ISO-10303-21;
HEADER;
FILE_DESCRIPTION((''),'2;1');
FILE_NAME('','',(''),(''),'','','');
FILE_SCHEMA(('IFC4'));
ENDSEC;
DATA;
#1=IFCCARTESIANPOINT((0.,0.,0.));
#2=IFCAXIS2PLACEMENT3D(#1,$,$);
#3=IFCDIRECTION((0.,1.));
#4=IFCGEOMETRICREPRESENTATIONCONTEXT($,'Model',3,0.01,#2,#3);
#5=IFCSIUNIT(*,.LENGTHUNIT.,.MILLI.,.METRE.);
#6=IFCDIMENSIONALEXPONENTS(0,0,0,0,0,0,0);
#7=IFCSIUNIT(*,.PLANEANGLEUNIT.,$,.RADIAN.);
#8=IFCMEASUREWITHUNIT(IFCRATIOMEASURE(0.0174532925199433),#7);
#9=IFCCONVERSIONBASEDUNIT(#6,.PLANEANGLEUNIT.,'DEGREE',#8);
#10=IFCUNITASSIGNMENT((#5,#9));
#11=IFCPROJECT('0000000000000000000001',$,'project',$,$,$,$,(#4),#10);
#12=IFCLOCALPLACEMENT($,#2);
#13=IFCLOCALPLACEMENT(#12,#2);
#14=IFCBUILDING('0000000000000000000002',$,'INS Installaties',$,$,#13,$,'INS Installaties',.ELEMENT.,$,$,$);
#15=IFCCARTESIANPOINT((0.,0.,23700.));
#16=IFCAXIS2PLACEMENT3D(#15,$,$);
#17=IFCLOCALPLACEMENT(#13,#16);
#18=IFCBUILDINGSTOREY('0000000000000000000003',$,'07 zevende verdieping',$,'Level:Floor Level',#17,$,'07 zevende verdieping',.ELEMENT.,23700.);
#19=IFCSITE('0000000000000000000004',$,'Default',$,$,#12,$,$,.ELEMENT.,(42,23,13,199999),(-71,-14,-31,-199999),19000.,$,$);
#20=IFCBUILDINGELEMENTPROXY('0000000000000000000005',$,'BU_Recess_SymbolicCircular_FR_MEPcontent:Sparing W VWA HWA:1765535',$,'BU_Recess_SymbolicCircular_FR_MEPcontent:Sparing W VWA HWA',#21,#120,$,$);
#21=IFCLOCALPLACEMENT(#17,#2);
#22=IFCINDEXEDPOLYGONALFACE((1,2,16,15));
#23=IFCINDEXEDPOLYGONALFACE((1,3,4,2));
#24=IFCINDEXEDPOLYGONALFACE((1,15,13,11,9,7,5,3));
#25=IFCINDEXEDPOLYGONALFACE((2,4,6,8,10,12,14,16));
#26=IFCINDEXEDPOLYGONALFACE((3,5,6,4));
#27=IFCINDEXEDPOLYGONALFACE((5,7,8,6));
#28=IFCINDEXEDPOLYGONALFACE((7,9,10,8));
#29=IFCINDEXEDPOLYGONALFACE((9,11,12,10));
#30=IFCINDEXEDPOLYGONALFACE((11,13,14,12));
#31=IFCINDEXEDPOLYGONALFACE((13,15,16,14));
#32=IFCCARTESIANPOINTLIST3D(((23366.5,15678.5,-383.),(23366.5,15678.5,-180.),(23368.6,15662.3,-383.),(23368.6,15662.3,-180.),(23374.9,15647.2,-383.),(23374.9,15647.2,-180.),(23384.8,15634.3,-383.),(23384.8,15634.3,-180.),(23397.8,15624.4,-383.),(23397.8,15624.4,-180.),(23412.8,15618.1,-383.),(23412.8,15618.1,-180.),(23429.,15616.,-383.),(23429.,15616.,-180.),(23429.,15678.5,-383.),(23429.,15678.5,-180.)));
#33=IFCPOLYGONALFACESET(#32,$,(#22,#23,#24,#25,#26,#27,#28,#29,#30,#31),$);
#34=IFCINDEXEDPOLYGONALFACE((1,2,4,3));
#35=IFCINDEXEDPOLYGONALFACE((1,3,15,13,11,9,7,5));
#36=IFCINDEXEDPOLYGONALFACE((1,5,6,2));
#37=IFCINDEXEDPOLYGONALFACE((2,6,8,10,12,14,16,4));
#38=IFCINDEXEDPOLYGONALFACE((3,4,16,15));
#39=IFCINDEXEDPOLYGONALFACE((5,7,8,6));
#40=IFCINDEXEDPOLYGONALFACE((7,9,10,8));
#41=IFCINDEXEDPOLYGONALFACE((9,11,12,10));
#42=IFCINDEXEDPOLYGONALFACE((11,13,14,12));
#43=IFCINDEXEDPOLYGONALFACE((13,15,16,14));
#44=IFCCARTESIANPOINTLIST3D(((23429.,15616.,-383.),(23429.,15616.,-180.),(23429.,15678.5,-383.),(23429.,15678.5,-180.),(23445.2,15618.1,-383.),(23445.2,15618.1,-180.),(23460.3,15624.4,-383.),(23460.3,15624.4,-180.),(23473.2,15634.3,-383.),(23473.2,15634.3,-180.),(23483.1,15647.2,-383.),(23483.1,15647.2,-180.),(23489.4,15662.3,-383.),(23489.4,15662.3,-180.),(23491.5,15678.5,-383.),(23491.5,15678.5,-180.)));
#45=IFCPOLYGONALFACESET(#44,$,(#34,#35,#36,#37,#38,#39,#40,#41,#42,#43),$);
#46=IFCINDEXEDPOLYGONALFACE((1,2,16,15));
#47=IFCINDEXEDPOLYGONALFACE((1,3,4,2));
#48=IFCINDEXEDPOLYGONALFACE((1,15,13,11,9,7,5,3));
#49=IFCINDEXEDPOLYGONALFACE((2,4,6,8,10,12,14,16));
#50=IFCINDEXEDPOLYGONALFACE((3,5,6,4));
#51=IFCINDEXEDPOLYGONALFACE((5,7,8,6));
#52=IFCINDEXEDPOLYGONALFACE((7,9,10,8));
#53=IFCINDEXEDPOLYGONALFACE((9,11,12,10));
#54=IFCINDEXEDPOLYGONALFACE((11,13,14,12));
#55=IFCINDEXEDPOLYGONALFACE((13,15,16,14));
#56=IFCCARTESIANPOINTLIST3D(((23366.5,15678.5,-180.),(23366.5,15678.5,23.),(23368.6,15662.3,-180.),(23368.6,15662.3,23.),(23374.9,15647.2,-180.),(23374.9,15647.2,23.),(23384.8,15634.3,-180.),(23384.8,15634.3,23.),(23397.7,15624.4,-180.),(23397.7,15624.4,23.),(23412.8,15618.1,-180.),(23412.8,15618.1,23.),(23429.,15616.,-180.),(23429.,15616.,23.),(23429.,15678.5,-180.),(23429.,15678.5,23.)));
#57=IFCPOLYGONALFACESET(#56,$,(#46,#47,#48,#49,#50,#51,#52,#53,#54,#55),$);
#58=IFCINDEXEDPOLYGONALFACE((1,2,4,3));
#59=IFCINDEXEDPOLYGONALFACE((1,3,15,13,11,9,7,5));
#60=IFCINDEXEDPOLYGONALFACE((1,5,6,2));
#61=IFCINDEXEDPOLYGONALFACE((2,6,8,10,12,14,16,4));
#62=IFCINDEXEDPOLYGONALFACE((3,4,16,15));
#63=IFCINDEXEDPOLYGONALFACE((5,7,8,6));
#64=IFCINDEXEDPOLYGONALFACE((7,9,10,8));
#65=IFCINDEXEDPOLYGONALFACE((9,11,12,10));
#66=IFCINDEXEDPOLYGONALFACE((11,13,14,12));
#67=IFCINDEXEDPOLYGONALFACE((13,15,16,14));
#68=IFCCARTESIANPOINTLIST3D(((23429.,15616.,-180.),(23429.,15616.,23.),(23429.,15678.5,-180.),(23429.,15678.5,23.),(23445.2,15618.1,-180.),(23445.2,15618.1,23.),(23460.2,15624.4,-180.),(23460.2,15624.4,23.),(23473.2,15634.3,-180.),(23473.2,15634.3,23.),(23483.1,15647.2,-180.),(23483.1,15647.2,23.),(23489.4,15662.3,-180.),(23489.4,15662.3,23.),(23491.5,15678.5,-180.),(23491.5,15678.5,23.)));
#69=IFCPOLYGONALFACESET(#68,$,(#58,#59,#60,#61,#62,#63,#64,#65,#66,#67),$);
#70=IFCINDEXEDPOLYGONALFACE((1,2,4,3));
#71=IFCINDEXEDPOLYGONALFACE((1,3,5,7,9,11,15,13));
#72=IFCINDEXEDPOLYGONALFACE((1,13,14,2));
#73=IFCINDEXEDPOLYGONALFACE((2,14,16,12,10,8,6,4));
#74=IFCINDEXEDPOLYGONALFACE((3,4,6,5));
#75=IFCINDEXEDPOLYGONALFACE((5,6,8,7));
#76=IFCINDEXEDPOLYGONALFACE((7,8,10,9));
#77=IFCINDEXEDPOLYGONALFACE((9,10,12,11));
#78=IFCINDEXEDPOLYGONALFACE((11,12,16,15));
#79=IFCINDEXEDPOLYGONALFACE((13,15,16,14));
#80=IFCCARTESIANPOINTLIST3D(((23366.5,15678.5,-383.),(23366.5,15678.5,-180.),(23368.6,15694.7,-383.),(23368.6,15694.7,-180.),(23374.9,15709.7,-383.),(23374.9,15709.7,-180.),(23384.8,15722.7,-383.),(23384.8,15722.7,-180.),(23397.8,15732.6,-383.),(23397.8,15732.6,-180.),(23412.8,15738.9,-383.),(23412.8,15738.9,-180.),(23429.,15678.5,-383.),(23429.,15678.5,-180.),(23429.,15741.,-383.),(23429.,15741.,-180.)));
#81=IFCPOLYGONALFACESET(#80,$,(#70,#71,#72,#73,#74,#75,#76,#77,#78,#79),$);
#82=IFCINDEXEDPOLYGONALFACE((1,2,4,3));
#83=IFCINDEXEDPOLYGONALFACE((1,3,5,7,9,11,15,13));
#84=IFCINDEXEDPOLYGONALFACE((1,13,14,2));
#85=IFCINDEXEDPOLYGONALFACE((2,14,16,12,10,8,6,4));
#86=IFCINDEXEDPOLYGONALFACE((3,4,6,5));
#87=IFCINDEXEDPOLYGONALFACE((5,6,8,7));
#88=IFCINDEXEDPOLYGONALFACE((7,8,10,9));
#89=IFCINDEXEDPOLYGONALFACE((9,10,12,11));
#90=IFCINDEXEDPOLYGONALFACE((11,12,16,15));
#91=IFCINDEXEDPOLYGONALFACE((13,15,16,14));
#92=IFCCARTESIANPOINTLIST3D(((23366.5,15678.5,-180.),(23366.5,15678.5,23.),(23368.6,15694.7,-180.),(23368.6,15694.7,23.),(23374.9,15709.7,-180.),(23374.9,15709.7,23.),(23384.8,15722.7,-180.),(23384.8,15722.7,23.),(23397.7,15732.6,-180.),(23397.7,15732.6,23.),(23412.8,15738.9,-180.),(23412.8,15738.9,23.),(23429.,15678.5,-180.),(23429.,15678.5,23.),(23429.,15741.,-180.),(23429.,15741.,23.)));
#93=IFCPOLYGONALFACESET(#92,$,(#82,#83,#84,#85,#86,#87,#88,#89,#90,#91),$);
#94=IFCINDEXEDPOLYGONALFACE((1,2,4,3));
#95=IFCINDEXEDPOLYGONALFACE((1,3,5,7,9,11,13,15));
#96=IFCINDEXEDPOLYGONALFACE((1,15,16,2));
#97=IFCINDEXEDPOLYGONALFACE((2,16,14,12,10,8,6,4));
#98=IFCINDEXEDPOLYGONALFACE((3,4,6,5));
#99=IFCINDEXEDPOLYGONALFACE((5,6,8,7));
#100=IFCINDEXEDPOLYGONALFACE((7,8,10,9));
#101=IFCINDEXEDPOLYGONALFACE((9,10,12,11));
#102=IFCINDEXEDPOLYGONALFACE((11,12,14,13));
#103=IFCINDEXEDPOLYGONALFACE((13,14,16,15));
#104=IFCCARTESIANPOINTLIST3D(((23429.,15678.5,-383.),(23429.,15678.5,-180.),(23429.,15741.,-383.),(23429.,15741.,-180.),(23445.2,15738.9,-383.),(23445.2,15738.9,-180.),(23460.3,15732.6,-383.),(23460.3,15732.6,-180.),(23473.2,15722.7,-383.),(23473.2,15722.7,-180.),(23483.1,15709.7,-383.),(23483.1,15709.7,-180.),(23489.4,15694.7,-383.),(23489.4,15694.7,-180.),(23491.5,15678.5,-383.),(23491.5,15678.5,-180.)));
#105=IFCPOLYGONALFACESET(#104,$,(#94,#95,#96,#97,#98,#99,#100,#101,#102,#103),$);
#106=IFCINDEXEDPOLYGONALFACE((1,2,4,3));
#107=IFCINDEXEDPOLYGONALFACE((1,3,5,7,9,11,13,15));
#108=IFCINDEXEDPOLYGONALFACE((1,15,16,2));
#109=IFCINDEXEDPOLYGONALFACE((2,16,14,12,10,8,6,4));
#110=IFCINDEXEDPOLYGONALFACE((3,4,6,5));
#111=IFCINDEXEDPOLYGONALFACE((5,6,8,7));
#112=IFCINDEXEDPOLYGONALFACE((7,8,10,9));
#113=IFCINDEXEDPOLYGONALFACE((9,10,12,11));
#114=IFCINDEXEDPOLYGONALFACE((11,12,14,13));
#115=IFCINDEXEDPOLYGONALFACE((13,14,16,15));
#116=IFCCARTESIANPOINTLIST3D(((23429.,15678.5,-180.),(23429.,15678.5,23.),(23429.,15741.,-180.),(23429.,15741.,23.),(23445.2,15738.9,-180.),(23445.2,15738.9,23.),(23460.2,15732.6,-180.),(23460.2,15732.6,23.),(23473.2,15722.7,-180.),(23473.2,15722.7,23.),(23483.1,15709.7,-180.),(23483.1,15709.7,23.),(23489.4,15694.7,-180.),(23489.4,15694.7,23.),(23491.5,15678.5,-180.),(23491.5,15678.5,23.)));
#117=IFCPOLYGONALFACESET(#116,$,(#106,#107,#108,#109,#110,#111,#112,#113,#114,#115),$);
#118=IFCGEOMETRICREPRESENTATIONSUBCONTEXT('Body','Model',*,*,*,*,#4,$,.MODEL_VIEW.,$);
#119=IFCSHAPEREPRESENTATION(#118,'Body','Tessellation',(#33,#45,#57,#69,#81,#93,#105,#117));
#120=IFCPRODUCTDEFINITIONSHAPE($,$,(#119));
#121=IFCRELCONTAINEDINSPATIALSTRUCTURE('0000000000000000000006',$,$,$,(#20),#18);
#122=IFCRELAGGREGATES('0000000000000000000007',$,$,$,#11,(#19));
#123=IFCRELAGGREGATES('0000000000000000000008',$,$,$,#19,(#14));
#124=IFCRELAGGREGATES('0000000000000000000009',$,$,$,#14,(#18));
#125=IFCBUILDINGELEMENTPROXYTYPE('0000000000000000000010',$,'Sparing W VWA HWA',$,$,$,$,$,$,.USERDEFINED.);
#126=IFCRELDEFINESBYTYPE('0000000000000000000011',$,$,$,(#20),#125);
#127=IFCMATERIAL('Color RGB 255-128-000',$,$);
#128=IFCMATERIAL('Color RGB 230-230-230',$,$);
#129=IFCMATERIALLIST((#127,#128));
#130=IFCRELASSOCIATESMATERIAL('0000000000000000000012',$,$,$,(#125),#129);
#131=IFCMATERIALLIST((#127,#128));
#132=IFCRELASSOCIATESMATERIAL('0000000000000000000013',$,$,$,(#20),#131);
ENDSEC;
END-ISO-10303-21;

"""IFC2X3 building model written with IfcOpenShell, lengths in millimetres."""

from ifc_helpers import new_model, entity, si_unit, converted_unit, direction, frame, frame_2d, origin, place, context, subcontext, project, spatial, polyline, circle_curve, parameter, trimmed, segment, composite_curve, outline, extrude, source, transform, mapped, material, material_list, type_object, type_shapes, element, save


model = new_model("IFC2X3")

# Units and contexts
model_context = context("Model", 3, precision=0.01, world=origin(), true_north=direction((0.0, 1.0)))
body_context = subcontext(model_context, "Body", "Model", "MODEL_VIEW")
ifc_project = project(units=[si_unit("LENGTHUNIT", "METRE", prefix="MILLI"), converted_unit("PLANEANGLEUNIT", "DEGREE", entity("IfcRatioMeasure", 0.0174532925199433), si_unit("PLANEANGLEUNIT", "RADIAN"), dimensions=[0, 0, 0, 0, 0, 0, 0])], contexts=[model_context])

# Site, building, storey
site_placement = place(None, origin())
site = spatial("IfcSite", under=ifc_project, at=site_placement, Name="Default", CompositionType="ELEMENT", RefLatitude=(42, 23, 13, 199999), RefLongitude=(-71, -14, -31, -199999), RefElevation=19000.0)
building_placement = place(site_placement, origin())
building = spatial("IfcBuilding", under=site, at=building_placement, Name="INS Installaties", LongName="INS Installaties", CompositionType="ELEMENT")
storey_placement = place(building_placement, frame((0.0, 0.0, 23700.0)))
storey = spatial("IfcBuildingStorey", under=building, at=storey_placement, Name="07 zevende verdieping", ObjectType="Level:Floor Level", LongName="07 zevende verdieping", CompositionType="ELEMENT", Elevation=23700.0)

# Building element proxy
ifc_material_1 = material(Name="Color RGB 255-128-000")
ifc_material_2 = material(Name="Color RGB 230-230-230")
ifc_material_list_1 = material_list([ifc_material_1, ifc_material_2])
building_element_proxy_type_1 = type_object("IfcBuildingElementProxyType", Name="Sparing W VWA HWA", PredefinedType="USERDEFINED", material=ifc_material_list_1)
shared_shape_1 = source(origin(), body_context, "Body", "SweptSolid", [
    extrude(outline(composite_curve([segment(trimmed(circle_curve(frame_2d((20.8, 20.8), x_axis=(1.0, 0.0)), 62.5), [parameter(180.0)], [parameter(270.0)], True, "PARAMETER"), True, "CONTINUOUS"), segment(polyline([(20.8, -41.7), (20.8, 20.8)]), True, "CONTINUOUS"), segment(polyline([(20.8, 20.8), (-41.7, 20.8)]), True, "CONTINUOUS")], self_intersect=False)), frame((20.8, 20.8, -403.0), z_axis=(0.0, 0.0, 1.0), x_axis=(-1.0, 0.0, 0.0)), (0.0, 0.0, 1.0), 203.0),
    extrude(outline(composite_curve([segment(polyline([(-41.7, -20.8), (20.8, -20.8)]), True, "CONTINUOUS"), segment(polyline([(20.8, -20.8), (20.8, 41.7)]), True, "CONTINUOUS"), segment(trimmed(circle_curve(frame_2d((20.8, -20.8), x_axis=(1.0, 0.0)), 62.5), [parameter(90.0)], [parameter(180.0)], True, "PARAMETER"), True, "CONTINUOUS")], self_intersect=False)), frame((-20.8, 20.8, -403.0)), (0.0, 0.0, 1.0), 203.0),
    extrude(outline(composite_curve([segment(trimmed(circle_curve(frame_2d((20.8, 20.8), x_axis=(1.0, 0.0)), 62.5), [parameter(180.0)], [parameter(270.0)], True, "PARAMETER"), True, "CONTINUOUS"), segment(polyline([(20.8, -41.7), (20.8, 20.8)]), True, "CONTINUOUS"), segment(polyline([(20.8, 20.8), (-41.7, 20.8)]), True, "CONTINUOUS")], self_intersect=False)), frame((20.8, 20.8, -200.0), z_axis=(0.0, 0.0, 1.0), x_axis=(-1.0, 0.0, 0.0)), (0.0, 0.0, 1.0), 203.0),
    extrude(outline(composite_curve([segment(polyline([(-41.7, -20.8), (20.8, -20.8)]), True, "CONTINUOUS"), segment(polyline([(20.8, -20.8), (20.8, 41.7)]), True, "CONTINUOUS"), segment(trimmed(circle_curve(frame_2d((20.8, -20.8), x_axis=(1.0, 0.0)), 62.5), [parameter(90.0)], [parameter(180.0)], True, "PARAMETER"), True, "CONTINUOUS")], self_intersect=False)), frame((-20.8, 20.8, -200.0)), (0.0, 0.0, 1.0), 203.0),
    extrude(outline(composite_curve([segment(polyline([(-41.7, -20.8), (20.8, -20.8)]), True, "CONTINUOUS"), segment(polyline([(20.8, -20.8), (20.8, 41.7)]), True, "CONTINUOUS"), segment(trimmed(circle_curve(frame_2d((20.8, -20.8), x_axis=(1.0, 0.0)), 62.5), [parameter(90.0)], [parameter(180.0)], True, "PARAMETER"), True, "CONTINUOUS")], self_intersect=False)), frame((20.8, -20.8, -403.0), z_axis=(0.0, 0.0, 1.0), x_axis=(-1.0, 0.0, 0.0)), (0.0, 0.0, 1.0), 203.0),
    extrude(outline(composite_curve([segment(polyline([(-41.7, -20.8), (20.8, -20.8)]), True, "CONTINUOUS"), segment(polyline([(20.8, -20.8), (20.8, 41.7)]), True, "CONTINUOUS"), segment(trimmed(circle_curve(frame_2d((20.8, -20.8), x_axis=(1.0, 0.0)), 62.5), [parameter(90.0)], [parameter(180.0)], True, "PARAMETER"), True, "CONTINUOUS")], self_intersect=False)), frame((20.8, -20.8, -200.0), z_axis=(0.0, 0.0, 1.0), x_axis=(-1.0, 0.0, 0.0)), (0.0, 0.0, 1.0), 203.0),
    extrude(outline(composite_curve([segment(trimmed(circle_curve(frame_2d((20.8, 20.8), x_axis=(1.0, 0.0)), 62.5), [parameter(180.0)], [parameter(270.0)], True, "PARAMETER"), True, "CONTINUOUS"), segment(polyline([(20.8, -41.7), (20.8, 20.8)]), True, "CONTINUOUS"), segment(polyline([(20.8, 20.8), (-41.7, 20.8)]), True, "CONTINUOUS")], self_intersect=False)), frame((-20.8, -20.8, -403.0)), (0.0, 0.0, 1.0), 203.0),
    extrude(outline(composite_curve([segment(trimmed(circle_curve(frame_2d((20.8, 20.8), x_axis=(1.0, 0.0)), 62.5), [parameter(180.0)], [parameter(270.0)], True, "PARAMETER"), True, "CONTINUOUS"), segment(polyline([(20.8, -41.7), (20.8, 20.8)]), True, "CONTINUOUS"), segment(polyline([(20.8, 20.8), (-41.7, 20.8)]), True, "CONTINUOUS")], self_intersect=False)), frame((-20.8, -20.8, -200.0)), (0.0, 0.0, 1.0), 203.0),
])
type_shapes(building_element_proxy_type_1, [shared_shape_1])
ifc_material_list_2 = material_list([ifc_material_1, ifc_material_2])
proxy_1_placement = place(storey_placement, frame((23429.0, 15678.5, 20.0), z_axis=(0.0, 0.0, 1.0), x_axis=(-1.0, 0.0, 0.0)))
element("IfcBuildingElementProxy", 1, at=proxy_1_placement, inside=storey, type_object=building_element_proxy_type_1, material=ifc_material_list_2, Name="BU_Recess_SymbolicCircular_FR_MEPcontent:Sparing W VWA HWA:1765535", ObjectType="BU_Recess_SymbolicCircular_FR_MEPcontent:Sparing W VWA HWA", context=body_context, shape_type="MappedRepresentation", body=[
    mapped(shared_shape_1, transform((0.0, 0.0, 0.0), scale=1.0)),
])

save(model, "model.ifc")
